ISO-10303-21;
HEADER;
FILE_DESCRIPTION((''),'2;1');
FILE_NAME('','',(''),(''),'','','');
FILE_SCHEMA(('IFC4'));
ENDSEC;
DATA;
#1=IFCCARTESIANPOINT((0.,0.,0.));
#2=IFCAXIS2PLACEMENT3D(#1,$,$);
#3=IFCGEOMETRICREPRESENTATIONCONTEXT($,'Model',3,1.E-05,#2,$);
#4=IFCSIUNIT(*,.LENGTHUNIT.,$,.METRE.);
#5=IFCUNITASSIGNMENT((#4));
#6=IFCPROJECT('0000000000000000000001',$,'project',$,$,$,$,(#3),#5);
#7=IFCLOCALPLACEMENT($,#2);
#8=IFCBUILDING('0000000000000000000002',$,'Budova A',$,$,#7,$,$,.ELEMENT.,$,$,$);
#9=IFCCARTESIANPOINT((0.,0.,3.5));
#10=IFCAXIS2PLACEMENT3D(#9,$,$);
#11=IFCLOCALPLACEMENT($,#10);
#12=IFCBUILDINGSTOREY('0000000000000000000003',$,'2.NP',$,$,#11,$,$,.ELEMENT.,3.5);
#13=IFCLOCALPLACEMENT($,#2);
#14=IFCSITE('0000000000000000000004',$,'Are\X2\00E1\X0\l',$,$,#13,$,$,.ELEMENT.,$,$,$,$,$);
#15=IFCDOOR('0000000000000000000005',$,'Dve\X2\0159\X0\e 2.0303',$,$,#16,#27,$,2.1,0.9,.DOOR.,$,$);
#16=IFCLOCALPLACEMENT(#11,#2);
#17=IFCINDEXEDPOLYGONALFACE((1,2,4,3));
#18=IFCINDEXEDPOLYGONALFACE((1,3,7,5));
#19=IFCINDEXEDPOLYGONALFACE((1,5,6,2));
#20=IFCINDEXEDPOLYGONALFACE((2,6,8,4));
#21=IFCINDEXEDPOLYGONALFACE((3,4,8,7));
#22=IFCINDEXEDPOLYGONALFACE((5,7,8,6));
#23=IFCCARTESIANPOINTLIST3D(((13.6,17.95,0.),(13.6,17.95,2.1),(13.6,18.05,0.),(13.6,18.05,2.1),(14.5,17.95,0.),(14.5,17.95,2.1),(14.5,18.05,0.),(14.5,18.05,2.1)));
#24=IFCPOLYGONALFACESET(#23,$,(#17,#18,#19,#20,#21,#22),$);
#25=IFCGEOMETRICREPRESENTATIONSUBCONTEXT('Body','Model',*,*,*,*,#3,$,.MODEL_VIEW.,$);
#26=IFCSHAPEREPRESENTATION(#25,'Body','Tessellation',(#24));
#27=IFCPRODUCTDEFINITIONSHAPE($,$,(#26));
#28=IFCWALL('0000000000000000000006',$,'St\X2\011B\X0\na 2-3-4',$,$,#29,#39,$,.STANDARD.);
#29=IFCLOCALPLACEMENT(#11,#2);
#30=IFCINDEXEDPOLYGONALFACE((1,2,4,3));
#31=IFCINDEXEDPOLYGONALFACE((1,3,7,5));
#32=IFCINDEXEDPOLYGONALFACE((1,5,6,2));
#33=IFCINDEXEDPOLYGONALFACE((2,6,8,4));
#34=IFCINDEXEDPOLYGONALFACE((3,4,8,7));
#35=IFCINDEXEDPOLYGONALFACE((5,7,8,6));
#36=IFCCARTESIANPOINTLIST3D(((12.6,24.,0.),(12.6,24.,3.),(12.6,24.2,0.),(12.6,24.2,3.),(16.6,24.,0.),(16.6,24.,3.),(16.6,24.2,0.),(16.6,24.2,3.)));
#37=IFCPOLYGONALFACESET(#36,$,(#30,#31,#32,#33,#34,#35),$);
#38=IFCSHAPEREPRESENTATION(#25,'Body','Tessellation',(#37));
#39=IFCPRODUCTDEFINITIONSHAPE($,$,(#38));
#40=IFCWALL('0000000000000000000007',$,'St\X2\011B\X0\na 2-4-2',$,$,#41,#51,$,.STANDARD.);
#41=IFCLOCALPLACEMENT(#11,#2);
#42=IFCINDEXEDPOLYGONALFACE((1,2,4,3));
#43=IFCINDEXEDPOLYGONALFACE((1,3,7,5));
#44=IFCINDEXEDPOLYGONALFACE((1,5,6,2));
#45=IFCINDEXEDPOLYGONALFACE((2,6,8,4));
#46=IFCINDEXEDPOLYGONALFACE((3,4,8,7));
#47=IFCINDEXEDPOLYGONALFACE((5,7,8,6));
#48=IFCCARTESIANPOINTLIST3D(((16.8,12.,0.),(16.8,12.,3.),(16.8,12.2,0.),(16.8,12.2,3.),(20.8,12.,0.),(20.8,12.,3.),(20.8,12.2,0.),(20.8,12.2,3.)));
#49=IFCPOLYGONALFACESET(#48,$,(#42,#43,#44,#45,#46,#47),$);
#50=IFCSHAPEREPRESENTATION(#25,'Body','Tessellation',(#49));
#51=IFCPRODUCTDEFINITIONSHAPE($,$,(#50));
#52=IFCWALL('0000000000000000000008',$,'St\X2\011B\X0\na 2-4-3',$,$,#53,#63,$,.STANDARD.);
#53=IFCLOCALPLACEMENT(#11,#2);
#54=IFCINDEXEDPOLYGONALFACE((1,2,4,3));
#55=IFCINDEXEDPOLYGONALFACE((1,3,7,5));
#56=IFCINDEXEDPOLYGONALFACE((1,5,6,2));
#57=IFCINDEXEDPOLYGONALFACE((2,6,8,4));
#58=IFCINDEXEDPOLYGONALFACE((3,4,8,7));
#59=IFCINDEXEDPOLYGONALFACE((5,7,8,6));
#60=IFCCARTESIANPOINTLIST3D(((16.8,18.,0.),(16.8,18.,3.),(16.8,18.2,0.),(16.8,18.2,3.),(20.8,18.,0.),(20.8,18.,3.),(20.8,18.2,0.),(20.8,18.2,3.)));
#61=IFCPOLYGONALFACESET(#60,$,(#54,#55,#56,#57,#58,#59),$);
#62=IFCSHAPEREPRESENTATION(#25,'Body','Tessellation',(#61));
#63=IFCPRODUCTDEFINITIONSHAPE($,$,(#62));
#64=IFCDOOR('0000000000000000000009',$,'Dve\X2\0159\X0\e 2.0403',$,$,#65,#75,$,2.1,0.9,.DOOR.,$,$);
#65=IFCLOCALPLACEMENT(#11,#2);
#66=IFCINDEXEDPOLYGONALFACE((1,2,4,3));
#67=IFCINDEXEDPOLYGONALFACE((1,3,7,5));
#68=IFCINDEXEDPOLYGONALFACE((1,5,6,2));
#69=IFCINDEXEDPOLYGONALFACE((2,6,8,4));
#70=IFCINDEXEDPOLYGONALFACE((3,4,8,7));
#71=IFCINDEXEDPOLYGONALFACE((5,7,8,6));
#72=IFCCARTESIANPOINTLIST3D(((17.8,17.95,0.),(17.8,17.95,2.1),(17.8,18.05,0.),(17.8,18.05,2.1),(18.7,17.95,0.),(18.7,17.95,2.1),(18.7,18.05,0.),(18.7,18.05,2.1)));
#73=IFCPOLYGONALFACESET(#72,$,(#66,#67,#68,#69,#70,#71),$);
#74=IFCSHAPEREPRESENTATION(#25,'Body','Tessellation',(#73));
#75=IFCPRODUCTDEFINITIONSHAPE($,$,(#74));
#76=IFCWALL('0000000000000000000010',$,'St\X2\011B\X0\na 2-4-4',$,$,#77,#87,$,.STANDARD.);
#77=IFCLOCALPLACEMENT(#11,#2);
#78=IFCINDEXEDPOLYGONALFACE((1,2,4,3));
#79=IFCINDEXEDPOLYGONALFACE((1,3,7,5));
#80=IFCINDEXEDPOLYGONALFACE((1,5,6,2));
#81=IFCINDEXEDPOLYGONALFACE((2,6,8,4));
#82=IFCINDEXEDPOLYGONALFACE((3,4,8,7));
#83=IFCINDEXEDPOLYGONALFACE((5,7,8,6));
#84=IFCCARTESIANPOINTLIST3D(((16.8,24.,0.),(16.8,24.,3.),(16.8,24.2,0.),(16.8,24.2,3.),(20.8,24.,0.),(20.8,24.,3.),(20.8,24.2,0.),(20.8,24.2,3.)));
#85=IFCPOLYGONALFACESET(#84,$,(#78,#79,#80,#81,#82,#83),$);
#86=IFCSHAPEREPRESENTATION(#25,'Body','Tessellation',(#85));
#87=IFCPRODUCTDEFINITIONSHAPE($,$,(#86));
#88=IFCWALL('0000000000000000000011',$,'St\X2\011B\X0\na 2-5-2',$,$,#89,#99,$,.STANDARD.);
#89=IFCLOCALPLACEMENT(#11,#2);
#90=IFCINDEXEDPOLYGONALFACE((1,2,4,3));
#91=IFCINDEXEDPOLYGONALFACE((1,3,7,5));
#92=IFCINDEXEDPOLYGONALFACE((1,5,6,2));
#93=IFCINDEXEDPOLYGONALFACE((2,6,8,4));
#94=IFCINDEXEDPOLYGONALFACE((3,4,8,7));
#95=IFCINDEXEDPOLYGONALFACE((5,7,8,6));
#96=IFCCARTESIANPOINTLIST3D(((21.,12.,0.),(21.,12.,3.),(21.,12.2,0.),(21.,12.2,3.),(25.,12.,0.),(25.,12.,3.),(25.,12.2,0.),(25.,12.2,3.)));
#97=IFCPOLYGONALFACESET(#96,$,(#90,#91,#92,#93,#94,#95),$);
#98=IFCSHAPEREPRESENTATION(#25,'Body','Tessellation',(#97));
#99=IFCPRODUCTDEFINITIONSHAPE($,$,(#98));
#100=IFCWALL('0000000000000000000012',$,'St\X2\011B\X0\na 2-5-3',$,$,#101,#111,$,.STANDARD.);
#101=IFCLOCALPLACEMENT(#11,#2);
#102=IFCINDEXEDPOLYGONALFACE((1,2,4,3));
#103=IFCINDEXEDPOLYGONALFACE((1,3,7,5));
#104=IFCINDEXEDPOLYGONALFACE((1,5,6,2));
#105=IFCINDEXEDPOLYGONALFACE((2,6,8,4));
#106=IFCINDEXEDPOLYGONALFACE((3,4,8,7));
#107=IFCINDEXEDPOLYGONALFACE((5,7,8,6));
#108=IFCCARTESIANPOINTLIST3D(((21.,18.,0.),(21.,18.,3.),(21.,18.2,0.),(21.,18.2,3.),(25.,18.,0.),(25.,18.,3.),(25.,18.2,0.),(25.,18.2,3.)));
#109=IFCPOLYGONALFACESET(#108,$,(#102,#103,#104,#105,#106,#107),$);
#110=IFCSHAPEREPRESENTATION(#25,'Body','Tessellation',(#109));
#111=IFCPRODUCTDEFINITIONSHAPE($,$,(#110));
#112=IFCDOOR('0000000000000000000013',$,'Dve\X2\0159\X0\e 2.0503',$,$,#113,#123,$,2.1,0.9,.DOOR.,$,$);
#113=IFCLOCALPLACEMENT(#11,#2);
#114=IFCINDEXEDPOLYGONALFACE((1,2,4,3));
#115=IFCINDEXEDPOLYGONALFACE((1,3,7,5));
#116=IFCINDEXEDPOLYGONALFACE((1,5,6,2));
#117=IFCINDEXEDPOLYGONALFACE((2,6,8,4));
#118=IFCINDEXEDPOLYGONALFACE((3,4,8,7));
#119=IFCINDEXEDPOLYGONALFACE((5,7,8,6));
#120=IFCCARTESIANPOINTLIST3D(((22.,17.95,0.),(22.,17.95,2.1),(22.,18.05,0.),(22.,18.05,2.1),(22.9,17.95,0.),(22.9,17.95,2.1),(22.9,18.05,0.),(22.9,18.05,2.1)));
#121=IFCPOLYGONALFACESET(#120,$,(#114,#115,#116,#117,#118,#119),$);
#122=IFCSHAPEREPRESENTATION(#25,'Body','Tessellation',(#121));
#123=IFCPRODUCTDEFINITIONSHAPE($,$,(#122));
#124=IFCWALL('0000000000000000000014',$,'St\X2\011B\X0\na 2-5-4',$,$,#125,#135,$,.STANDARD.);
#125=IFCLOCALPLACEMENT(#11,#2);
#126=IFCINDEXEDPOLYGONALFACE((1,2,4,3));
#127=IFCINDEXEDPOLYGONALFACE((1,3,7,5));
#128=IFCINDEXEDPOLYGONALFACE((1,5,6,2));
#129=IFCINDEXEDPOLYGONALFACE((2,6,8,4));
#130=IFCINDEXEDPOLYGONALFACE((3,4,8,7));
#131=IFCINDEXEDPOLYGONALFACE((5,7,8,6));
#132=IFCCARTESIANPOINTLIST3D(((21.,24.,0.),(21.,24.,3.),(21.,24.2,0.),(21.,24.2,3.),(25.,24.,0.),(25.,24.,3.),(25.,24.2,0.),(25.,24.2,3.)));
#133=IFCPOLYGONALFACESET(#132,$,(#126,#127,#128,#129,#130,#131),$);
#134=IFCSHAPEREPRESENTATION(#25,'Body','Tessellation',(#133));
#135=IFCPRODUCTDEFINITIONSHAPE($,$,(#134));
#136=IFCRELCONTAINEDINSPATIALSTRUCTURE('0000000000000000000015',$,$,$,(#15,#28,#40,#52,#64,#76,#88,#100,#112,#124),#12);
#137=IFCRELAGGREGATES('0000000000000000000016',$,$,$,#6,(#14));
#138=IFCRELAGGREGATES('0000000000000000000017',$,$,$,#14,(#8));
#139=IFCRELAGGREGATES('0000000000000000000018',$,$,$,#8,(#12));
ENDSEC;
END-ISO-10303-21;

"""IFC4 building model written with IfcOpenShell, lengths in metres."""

from ifc_helpers import new_model, si_unit, frame, frame_2d, origin, place, context, subcontext, project, spatial, rectangle, extrude, element, save


model = new_model("IFC4")

# Units and contexts
model_context = context("Model", 3, precision=1e-05, world=origin())
body_context = subcontext(model_context, "Body", "Model", "MODEL_VIEW")
ifc_project = project(units=[si_unit("LENGTHUNIT", "METRE")], contexts=[model_context])

# Site, building, storey
site_placement = place(None, origin())
site = spatial("IfcSite", under=ifc_project, at=site_placement, Name="Areál", CompositionType="ELEMENT")
building_placement = place(None, origin())
building = spatial("IfcBuilding", under=site, at=building_placement, Name="Budova A", CompositionType="ELEMENT")
storey_placement = place(None, frame((0.0, 0.0, 3.5)))
storey = spatial("IfcBuildingStorey", under=building, at=storey_placement, Name="2.NP", CompositionType="ELEMENT", Elevation=3.5)

# Door
door_1_placement = place(storey_placement, frame((13.6, 17.95, 0.0)))
element("IfcDoor", 1, at=door_1_placement, inside=storey, Name="Dveře 2.0303", OverallHeight=2.1, OverallWidth=0.9, PredefinedType="DOOR", context=body_context, shape_type="SweptSolid", body=[
    extrude(rectangle(XDim=0.9, YDim=0.1, at=frame_2d((0.45, 0.05))), origin(), (0.0, 0.0, 1.0), 2.1),
])

# Walls
for number, where, name in (
    (2, (12.6, 24.0, 0.0), "Stěna 2-3-4"),
    (3, (16.8, 12.0, 0.0), "Stěna 2-4-2"),
    (4, (16.8, 18.0, 0.0), "Stěna 2-4-3"),
):
    element("IfcWall", number, at=place(storey_placement, frame(where)), inside=storey, Name=name, PredefinedType="STANDARD", context=body_context, shape_type="SweptSolid", body=[
        extrude(rectangle(XDim=4.0, YDim=0.2, at=frame_2d((2.0, 0.1))), origin(), (0.0, 0.0, 1.0), 3.0),
    ])

# Door
door_2_placement = place(storey_placement, frame((17.8, 17.95, 0.0)))
element("IfcDoor", 5, at=door_2_placement, inside=storey, Name="Dveře 2.0403", OverallHeight=2.1, OverallWidth=0.9, PredefinedType="DOOR", context=body_context, shape_type="SweptSolid", body=[
    extrude(rectangle(XDim=0.9, YDim=0.1, at=frame_2d((0.45, 0.05))), origin(), (0.0, 0.0, 1.0), 2.1),
])

# Walls
for number, where, name in (
    (6, (16.8, 24.0, 0.0), "Stěna 2-4-4"),
    (7, (21.0, 12.0, 0.0), "Stěna 2-5-2"),
    (8, (21.0, 18.0, 0.0), "Stěna 2-5-3"),
):
    element("IfcWall", number, at=place(storey_placement, frame(where)), inside=storey, Name=name, PredefinedType="STANDARD", context=body_context, shape_type="SweptSolid", body=[
        extrude(rectangle(XDim=4.0, YDim=0.2, at=frame_2d((2.0, 0.1))), origin(), (0.0, 0.0, 1.0), 3.0),
    ])

# Door
door_3_placement = place(storey_placement, frame((22.0, 17.95, 0.0)))
element("IfcDoor", 9, at=door_3_placement, inside=storey, Name="Dveře 2.0503", OverallHeight=2.1, OverallWidth=0.9, PredefinedType="DOOR", context=body_context, shape_type="SweptSolid", body=[
    extrude(rectangle(XDim=0.9, YDim=0.1, at=frame_2d((0.45, 0.05))), origin(), (0.0, 0.0, 1.0), 2.1),
])

# Wall
wall_1_placement = place(storey_placement, frame((21.0, 24.0, 0.0)))
element("IfcWall", 10, at=wall_1_placement, inside=storey, Name="Stěna 2-5-4", PredefinedType="STANDARD", context=body_context, shape_type="SweptSolid", body=[
    extrude(rectangle(XDim=4.0, YDim=0.2, at=frame_2d((2.0, 0.1))), origin(), (0.0, 0.0, 1.0), 3.0),
])

save(model, "model.ifc")
